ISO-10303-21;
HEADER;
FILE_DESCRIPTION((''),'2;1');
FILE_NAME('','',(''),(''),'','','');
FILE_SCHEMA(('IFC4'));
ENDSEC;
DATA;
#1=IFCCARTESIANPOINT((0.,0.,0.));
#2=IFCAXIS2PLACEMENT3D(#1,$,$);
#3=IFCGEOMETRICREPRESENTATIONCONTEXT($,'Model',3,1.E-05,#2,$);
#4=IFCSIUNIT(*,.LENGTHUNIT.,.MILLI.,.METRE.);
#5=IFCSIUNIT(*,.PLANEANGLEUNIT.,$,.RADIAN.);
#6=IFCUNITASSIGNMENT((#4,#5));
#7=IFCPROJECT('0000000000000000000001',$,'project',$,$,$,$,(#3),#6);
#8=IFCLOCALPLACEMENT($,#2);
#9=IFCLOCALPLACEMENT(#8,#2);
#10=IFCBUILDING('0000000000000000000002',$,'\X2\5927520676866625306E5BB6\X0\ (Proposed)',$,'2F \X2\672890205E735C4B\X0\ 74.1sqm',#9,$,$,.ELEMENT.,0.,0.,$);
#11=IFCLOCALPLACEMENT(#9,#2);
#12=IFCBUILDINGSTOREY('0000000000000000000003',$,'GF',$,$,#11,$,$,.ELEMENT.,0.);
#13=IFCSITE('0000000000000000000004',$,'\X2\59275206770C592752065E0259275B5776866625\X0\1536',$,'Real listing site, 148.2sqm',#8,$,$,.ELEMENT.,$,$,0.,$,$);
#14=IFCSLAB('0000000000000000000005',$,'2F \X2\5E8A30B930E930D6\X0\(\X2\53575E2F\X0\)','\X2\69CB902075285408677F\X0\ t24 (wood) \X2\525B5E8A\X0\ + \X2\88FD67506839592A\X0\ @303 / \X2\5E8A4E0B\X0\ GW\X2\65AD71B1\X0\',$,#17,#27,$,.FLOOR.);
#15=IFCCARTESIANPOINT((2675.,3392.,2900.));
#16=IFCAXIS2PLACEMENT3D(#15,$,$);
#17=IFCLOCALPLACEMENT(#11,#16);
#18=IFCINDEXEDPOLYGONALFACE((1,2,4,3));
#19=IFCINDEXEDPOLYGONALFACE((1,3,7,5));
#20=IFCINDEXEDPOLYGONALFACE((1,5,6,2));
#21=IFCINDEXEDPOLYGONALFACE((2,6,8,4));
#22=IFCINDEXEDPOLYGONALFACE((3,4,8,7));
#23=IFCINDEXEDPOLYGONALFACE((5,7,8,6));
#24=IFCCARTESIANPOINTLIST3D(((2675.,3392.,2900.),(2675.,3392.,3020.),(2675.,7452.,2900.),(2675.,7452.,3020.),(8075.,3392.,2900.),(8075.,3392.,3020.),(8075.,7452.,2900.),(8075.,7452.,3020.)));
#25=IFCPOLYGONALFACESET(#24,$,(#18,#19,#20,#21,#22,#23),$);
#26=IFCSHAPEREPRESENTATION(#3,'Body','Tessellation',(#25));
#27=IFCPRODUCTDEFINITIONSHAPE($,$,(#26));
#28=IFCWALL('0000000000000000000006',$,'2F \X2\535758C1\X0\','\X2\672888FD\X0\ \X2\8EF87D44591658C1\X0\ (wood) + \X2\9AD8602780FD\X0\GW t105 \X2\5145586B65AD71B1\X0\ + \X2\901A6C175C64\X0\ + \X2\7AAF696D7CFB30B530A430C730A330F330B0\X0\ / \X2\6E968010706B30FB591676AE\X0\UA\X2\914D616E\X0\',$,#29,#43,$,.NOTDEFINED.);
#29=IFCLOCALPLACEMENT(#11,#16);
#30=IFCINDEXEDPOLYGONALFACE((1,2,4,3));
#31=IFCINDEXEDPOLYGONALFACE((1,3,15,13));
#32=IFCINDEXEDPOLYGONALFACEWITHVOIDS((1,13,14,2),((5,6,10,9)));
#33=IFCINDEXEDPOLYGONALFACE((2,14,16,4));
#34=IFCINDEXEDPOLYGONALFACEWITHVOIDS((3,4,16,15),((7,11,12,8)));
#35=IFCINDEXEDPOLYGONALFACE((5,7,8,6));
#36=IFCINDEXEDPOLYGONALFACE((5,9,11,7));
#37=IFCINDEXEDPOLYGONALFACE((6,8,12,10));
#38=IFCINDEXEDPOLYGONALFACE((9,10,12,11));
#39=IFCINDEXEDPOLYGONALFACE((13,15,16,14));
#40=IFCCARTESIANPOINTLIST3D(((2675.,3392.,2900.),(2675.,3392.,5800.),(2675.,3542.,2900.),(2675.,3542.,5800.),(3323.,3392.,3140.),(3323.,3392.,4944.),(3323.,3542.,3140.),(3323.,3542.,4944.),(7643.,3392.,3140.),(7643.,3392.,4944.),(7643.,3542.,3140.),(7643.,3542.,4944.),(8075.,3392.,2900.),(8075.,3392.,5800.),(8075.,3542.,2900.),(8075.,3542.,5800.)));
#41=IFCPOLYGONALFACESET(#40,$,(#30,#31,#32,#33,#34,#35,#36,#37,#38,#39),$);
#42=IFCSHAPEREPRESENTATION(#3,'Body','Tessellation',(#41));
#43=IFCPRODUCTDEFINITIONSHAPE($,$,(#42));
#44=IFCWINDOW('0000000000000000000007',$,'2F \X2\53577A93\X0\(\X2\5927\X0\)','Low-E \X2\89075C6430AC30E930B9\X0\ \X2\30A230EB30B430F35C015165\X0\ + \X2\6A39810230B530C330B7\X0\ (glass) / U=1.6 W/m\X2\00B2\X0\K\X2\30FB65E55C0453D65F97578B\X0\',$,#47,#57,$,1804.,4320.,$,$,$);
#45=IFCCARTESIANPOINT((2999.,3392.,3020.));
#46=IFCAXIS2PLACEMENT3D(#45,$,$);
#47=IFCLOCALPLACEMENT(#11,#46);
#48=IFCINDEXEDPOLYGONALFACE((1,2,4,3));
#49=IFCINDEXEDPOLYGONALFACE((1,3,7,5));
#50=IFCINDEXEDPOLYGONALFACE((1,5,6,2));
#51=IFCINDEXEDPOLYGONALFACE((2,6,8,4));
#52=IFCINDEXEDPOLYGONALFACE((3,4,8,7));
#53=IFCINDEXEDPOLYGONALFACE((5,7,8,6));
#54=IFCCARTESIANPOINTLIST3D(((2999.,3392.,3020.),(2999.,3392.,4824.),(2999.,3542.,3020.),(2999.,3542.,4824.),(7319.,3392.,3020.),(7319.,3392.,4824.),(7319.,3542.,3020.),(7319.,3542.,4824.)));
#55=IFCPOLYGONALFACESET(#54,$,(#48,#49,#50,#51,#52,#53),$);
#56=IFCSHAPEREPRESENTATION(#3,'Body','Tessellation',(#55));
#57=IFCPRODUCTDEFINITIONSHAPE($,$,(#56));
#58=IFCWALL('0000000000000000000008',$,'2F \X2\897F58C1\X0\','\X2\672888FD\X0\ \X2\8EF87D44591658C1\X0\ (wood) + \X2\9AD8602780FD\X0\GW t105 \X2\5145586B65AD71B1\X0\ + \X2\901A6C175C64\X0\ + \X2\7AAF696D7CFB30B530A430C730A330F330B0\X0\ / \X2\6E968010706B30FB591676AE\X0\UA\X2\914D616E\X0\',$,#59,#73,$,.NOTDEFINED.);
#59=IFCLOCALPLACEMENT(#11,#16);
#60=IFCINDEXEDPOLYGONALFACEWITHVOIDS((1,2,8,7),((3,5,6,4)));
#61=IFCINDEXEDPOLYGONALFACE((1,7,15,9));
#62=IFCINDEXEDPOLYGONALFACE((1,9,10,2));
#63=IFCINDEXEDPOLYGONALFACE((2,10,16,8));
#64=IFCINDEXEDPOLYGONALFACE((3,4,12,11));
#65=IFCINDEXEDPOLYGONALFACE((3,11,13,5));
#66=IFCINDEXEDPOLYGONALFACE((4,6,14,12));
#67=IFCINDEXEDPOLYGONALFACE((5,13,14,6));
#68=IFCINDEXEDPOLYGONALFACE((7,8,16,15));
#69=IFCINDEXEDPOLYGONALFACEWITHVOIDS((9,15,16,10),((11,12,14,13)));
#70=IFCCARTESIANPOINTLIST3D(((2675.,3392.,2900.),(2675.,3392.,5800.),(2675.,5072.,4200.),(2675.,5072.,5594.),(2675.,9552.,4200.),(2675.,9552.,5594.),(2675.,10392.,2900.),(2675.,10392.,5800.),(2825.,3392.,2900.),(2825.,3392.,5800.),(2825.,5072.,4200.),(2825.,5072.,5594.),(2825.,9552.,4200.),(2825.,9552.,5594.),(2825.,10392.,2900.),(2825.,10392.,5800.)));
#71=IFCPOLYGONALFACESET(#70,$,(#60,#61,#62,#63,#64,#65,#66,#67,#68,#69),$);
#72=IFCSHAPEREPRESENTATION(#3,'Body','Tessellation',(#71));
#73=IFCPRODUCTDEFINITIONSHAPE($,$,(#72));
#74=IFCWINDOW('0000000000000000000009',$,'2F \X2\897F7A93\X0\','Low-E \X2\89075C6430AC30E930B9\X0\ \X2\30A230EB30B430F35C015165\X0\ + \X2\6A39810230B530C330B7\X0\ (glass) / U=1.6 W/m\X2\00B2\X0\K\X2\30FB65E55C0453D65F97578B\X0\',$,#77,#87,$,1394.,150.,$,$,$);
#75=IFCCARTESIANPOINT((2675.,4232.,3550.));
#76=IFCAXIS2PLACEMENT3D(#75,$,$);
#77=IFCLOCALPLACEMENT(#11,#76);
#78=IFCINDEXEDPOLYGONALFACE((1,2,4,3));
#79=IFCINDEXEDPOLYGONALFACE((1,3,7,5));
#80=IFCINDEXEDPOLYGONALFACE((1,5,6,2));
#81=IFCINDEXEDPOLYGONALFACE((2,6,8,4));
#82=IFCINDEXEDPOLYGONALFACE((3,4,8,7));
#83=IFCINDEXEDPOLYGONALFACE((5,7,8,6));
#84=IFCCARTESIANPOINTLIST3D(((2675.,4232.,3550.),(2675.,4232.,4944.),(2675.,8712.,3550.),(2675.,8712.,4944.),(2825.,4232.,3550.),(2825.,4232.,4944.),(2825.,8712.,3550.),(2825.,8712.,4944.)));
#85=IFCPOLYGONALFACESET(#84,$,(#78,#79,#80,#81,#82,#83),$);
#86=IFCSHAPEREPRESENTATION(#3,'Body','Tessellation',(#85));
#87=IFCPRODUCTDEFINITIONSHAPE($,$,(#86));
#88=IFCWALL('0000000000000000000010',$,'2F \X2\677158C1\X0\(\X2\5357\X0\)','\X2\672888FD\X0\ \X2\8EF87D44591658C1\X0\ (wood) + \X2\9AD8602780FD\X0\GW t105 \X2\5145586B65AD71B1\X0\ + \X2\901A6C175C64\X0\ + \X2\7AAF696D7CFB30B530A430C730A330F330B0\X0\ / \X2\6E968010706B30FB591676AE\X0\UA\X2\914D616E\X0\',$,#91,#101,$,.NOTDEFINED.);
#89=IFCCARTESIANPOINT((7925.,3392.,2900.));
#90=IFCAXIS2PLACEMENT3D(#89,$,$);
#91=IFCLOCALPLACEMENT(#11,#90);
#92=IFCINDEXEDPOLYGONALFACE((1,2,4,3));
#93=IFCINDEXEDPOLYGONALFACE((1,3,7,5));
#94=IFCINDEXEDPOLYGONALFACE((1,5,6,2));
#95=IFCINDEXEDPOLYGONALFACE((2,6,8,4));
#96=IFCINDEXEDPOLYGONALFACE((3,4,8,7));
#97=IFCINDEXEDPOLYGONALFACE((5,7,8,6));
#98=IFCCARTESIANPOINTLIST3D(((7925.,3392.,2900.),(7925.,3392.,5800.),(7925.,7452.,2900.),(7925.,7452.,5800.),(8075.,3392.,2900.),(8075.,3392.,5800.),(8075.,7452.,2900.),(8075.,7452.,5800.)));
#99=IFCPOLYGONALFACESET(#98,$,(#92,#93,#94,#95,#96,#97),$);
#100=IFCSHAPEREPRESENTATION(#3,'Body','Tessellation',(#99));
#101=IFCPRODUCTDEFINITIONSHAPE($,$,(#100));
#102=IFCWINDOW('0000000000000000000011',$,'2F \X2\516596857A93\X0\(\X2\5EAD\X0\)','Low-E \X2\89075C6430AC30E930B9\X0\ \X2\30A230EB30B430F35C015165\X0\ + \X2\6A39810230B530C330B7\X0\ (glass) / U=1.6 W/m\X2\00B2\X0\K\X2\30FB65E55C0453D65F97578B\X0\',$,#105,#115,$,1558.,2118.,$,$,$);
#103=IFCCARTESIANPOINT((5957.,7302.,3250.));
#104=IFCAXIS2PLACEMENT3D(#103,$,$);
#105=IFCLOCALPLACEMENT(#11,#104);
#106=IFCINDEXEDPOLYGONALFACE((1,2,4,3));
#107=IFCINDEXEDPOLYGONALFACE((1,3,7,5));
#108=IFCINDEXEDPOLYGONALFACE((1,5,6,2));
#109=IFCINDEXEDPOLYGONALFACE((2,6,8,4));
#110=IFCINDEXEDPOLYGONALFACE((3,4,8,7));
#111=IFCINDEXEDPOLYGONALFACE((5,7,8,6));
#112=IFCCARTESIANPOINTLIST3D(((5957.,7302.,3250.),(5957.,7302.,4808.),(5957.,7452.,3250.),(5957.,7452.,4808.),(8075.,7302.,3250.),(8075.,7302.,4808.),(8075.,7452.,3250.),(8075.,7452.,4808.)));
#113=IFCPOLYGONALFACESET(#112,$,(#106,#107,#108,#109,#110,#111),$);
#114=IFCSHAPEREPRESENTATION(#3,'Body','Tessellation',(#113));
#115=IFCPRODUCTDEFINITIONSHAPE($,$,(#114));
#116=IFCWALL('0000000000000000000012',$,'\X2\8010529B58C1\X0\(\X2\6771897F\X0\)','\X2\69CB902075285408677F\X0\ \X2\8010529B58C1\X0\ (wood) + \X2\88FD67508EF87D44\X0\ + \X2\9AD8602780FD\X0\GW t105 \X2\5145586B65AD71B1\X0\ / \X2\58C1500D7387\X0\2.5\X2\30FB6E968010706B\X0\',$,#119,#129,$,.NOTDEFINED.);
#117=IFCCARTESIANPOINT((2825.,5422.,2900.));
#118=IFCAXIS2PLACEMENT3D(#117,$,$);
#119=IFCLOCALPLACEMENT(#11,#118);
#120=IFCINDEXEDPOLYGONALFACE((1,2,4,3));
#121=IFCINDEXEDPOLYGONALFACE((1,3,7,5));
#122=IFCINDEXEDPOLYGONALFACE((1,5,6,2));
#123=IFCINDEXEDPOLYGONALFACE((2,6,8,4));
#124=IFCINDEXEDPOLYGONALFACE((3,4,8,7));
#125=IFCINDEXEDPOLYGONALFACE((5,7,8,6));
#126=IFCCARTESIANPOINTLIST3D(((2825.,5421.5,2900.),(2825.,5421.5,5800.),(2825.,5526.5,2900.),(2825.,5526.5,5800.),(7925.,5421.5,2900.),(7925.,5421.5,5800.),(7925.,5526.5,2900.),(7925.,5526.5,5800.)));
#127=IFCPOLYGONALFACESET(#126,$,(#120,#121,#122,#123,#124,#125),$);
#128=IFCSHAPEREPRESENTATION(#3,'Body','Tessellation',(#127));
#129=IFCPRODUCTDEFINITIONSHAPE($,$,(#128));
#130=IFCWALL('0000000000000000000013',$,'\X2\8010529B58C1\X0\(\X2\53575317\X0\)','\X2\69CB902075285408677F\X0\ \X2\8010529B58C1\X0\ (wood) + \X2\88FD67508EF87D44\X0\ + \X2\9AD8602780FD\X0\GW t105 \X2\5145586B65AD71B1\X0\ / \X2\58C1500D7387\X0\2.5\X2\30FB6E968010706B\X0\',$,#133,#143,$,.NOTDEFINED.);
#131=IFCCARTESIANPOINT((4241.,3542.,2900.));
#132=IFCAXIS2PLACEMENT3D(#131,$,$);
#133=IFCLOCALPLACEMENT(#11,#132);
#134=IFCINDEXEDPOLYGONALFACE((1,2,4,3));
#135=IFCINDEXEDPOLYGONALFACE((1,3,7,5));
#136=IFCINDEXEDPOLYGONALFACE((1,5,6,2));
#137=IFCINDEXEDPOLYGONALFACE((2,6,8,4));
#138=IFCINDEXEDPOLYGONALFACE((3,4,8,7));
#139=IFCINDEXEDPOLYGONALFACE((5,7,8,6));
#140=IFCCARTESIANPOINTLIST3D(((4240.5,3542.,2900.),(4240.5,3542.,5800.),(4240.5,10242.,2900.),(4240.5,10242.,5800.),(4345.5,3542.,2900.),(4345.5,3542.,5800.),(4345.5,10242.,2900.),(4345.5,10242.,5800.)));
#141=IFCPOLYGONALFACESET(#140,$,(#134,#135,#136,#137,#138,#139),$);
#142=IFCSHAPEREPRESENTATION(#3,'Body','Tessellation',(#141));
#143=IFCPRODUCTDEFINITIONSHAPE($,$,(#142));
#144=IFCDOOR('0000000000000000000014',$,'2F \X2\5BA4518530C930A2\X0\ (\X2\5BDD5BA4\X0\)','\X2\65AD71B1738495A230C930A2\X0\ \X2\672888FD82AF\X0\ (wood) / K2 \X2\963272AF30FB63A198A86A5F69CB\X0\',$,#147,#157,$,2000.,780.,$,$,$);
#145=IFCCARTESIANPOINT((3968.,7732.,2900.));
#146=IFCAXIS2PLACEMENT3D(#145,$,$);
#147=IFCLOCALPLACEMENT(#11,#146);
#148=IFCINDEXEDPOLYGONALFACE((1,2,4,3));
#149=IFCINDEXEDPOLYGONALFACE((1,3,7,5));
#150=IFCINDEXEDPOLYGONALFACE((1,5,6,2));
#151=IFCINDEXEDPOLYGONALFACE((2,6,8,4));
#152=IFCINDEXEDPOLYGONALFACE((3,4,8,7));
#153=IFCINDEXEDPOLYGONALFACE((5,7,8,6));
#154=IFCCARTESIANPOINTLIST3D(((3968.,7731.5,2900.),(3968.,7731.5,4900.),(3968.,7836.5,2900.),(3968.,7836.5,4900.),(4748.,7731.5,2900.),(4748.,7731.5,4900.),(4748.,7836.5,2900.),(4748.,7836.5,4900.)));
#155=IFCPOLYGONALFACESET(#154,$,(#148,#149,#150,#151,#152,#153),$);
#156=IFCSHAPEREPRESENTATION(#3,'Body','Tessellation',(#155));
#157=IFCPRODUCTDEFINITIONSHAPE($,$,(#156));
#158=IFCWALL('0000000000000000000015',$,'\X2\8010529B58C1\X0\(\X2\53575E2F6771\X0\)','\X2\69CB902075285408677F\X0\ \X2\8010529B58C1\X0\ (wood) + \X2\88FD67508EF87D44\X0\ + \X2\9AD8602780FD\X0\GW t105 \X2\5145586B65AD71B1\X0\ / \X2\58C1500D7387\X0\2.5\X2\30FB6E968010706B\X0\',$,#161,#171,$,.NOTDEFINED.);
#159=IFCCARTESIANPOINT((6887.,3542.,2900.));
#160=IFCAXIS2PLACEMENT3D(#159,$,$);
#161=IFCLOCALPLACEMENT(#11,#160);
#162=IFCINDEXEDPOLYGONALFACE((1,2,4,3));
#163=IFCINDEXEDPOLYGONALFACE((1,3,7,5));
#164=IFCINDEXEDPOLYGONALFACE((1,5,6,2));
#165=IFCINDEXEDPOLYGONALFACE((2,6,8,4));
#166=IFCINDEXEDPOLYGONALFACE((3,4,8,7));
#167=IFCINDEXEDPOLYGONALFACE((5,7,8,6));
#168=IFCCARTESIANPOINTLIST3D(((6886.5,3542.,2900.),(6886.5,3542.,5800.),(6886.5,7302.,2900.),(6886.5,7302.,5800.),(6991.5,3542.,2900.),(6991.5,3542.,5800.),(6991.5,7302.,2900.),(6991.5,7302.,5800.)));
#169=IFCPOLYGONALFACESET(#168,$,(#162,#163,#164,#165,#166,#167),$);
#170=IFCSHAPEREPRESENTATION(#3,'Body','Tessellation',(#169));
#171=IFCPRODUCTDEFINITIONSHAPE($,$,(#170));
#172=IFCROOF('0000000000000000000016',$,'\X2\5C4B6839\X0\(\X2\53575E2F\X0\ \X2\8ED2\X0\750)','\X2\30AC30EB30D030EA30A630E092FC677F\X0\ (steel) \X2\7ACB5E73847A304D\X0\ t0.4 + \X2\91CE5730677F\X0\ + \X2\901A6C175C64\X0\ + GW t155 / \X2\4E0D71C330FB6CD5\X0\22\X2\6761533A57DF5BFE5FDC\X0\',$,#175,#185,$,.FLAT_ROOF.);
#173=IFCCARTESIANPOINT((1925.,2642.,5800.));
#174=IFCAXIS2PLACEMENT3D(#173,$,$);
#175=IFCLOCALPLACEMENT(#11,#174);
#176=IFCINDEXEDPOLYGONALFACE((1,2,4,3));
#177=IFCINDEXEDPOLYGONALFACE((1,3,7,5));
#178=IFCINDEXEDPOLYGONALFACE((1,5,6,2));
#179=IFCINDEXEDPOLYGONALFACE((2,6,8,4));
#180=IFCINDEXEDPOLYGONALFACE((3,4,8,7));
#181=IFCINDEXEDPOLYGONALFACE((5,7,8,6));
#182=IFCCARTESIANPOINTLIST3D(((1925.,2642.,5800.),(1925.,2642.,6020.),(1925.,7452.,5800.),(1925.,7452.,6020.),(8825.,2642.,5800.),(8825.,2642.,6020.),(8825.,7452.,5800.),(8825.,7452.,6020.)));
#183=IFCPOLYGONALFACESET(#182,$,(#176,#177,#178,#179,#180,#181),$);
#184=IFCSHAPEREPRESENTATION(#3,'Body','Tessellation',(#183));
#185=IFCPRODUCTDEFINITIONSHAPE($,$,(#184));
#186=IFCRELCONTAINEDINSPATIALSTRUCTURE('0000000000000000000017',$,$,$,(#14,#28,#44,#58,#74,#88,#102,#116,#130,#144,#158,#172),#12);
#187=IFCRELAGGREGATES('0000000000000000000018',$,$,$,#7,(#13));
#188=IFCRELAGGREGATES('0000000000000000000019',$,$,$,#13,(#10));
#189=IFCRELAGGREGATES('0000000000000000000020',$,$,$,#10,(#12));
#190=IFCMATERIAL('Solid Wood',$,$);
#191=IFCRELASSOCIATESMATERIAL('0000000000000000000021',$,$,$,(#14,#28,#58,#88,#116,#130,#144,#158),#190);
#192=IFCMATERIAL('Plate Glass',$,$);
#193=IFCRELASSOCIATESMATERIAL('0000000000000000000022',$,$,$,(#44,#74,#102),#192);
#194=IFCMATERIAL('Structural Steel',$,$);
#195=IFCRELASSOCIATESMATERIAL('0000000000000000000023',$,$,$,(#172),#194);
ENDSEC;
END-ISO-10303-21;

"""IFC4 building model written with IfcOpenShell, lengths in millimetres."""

from ifc_helpers import new_model, si_unit, frame, frame_2d, origin, place, context, project, spatial, rectangle, extrude, material, element, fill, save


model = new_model("IFC4")

# Units and contexts
model_context = context("Model", 3, precision=1e-05, world=origin())
ifc_project = project(units=[si_unit("LENGTHUNIT", "METRE", prefix="MILLI"), si_unit("PLANEANGLEUNIT", "RADIAN")], contexts=[model_context])

# Site, building, storey
site_placement = place(None, origin())
site = spatial("IfcSite", under=ifc_project, at=site_placement, Name="大分県大分市大字皆春1536", ObjectType="Real listing site, 148.2sqm", CompositionType="ELEMENT", RefElevation=0.0)
building_placement = place(site_placement, origin())
building = spatial("IfcBuilding", under=site, at=building_placement, Name="大分皆春の家 (Proposed)", ObjectType="2F 木造平屋 74.1sqm", CompositionType="ELEMENT", ElevationOfRefHeight=0.0, ElevationOfTerrain=0.0)
storey_placement = place(building_placement, origin())
storey = spatial("IfcBuildingStorey", under=building, at=storey_placement, Name="GF", CompositionType="ELEMENT", Elevation=0.0)

# Slab
ifc_material_1 = material(Name="Solid Wood")
slab_placement = place(storey_placement, frame((2675.0, 3392.0, 2900.0)))
element("IfcSlab", 1, at=slab_placement, inside=storey, material=ifc_material_1, Name="2F 床スラブ(南帯)", Description="構造用合板 t24 (wood) 剛床 + 製材根太 @303 / 床下 GW断熱", PredefinedType="FLOOR", context=model_context, shape_type="SweptSolid", body=[
    extrude(rectangle(XDim=5400.0, YDim=4060.0, at=frame_2d((2700.0, 2030.0))), frame((2675.0, 3392.0, 2900.0)), (0.0, 0.0, 1.0), 120.0),
])

# Walls, openings, windows
wall_1_placement = place(storey_placement, frame((2675.0, 3392.0, 2900.0)))
wall_1 = element("IfcWall", 2, at=wall_1_placement, inside=storey, material=ifc_material_1, Name="2F 南壁", Description="木製 軸組外壁 (wood) + 高性能GW t105 充填断熱 + 通気層 + 窯業系サイディング / 準耐火・外皮UA配慮", PredefinedType="NOTDEFINED", context=model_context, shape_type="SweptSolid", body=[
    extrude(rectangle(XDim=5400.0, YDim=150.0, at=frame_2d((2700.0, 75.0))), frame((2675.0, 3392.0, 2900.0)), (0.0, 0.0, 1.0), 2900.0),
])
opening_1_placement = place(storey_placement, frame((2999.0, 3392.0, 3020.0)))
opening_1 = element("IfcOpeningElement", 3, at=opening_1_placement, cuts=wall_1, PredefinedType="NOTDEFINED", context=model_context, shape_type="SweptSolid", body=[
    extrude(rectangle(XDim=4320.0, YDim=150.0, at=frame_2d((2160.0, 75.0))), frame((2999.0, 3392.0, 3020.0)), (0.0, 0.0, 1.0), 1804.0),
])
ifc_material_2 = material(Name="Plate Glass")
window_1_placement = place(storey_placement, frame((2999.0, 3392.0, 3020.0)))
window_1 = element("IfcWindow", 4, at=window_1_placement, inside=storey, material=ifc_material_2, Name="2F 南窓(大)", Description="Low-E 複層ガラス アルゴン封入 + 樹脂サッシ (glass) / U=1.6 W/m²K・日射取得型", OverallHeight=1804.0, OverallWidth=4320.0, context=model_context, shape_type="SweptSolid", body=[
    extrude(rectangle(XDim=4320.0, YDim=150.0, at=frame_2d((2160.0, 75.0))), frame((2999.0, 3392.0, 3020.0)), (0.0, 0.0, 1.0), 1804.0),
])
fill(opening_1, window_1)
wall_2_placement = place(storey_placement, frame((2675.0, 3392.0, 2900.0)))
wall_2 = element("IfcWall", 5, at=wall_2_placement, inside=storey, material=ifc_material_1, Name="2F 西壁", Description="木製 軸組外壁 (wood) + 高性能GW t105 充填断熱 + 通気層 + 窯業系サイディング / 準耐火・外皮UA配慮", PredefinedType="NOTDEFINED", context=model_context, shape_type="SweptSolid", body=[
    extrude(rectangle(XDim=150.0, YDim=7000.0, at=frame_2d((75.0, 3500.0))), frame((2675.0, 3392.0, 2900.0)), (0.0, 0.0, 1.0), 2900.0),
])
opening_2_placement = place(storey_placement, frame((2675.0, 4232.0, 3550.0)))
opening_2 = element("IfcOpeningElement", 6, at=opening_2_placement, cuts=wall_2, PredefinedType="NOTDEFINED", context=model_context, shape_type="SweptSolid", body=[
    extrude(rectangle(XDim=150.0, YDim=4480.0, at=frame_2d((75.0, 2240.0))), frame((2675.0, 4232.0, 3550.0)), (0.0, 0.0, 1.0), 1394.0),
])
window_2_placement = place(storey_placement, frame((2675.0, 4232.0, 3550.0)))
window_2 = element("IfcWindow", 7, at=window_2_placement, inside=storey, material=ifc_material_2, Name="2F 西窓", Description="Low-E 複層ガラス アルゴン封入 + 樹脂サッシ (glass) / U=1.6 W/m²K・日射取得型", OverallHeight=1394.0, OverallWidth=150.0, context=model_context, shape_type="SweptSolid", body=[
    extrude(rectangle(XDim=150.0, YDim=4480.0, at=frame_2d((75.0, 2240.0))), frame((2675.0, 4232.0, 3550.0)), (0.0, 0.0, 1.0), 1394.0),
])
fill(opening_2, window_2)
wall_3_placement = place(storey_placement, frame((7925.0, 3392.0, 2900.0)))
wall_3 = element("IfcWall", 8, at=wall_3_placement, inside=storey, material=ifc_material_1, Name="2F 東壁(南)", Description="木製 軸組外壁 (wood) + 高性能GW t105 充填断熱 + 通気層 + 窯業系サイディング / 準耐火・外皮UA配慮", PredefinedType="NOTDEFINED", context=model_context, shape_type="SweptSolid", body=[
    extrude(rectangle(XDim=150.0, YDim=4060.0, at=frame_2d((75.0, 2030.0))), frame((7925.0, 3392.0, 2900.0)), (0.0, 0.0, 1.0), 2900.0),
])
opening_3_placement = place(storey_placement, frame((5957.0, 7302.0, 3250.0)))
opening_3 = element("IfcOpeningElement", 9, at=opening_3_placement, cuts=wall_3, PredefinedType="NOTDEFINED", context=model_context, shape_type="SweptSolid", body=[
    extrude(rectangle(XDim=2118.0, YDim=150.0, at=frame_2d((1059.0, 75.0))), frame((5957.0, 7302.0, 3250.0)), (0.0, 0.0, 1.0), 1558.0),
])
window_3_placement = place(storey_placement, frame((5957.0, 7302.0, 3250.0)))
window_3 = element("IfcWindow", 10, at=window_3_placement, inside=storey, material=ifc_material_2, Name="2F 入隅窓(庭)", Description="Low-E 複層ガラス アルゴン封入 + 樹脂サッシ (glass) / U=1.6 W/m²K・日射取得型", OverallHeight=1558.0, OverallWidth=2118.0, context=model_context, shape_type="SweptSolid", body=[
    extrude(rectangle(XDim=2118.0, YDim=150.0, at=frame_2d((1059.0, 75.0))), frame((5957.0, 7302.0, 3250.0)), (0.0, 0.0, 1.0), 1558.0),
])
fill(opening_3, window_3)

# Wall
wall_4_placement = place(storey_placement, frame((2825.0, 5422.0, 2900.0)))
element("IfcWall", 11, at=wall_4_placement, inside=storey, material=ifc_material_1, Name="耐力壁(東西)", Description="構造用合板 耐力壁 (wood) + 製材軸組 + 高性能GW t105 充填断熱 / 壁倍率2.5・準耐火", PredefinedType="NOTDEFINED", context=model_context, shape_type="SweptSolid", body=[
    extrude(rectangle(XDim=5100.0, YDim=105.0, at=frame_2d((2550.0, 52.0))), frame((2825.0, 5422.0, 2900.0)), (0.0, 0.0, 1.0), 2900.0),
])

# Wall, opening, door
wall_5_placement = place(storey_placement, frame((4241.0, 3542.0, 2900.0)))
wall_5 = element("IfcWall", 12, at=wall_5_placement, inside=storey, material=ifc_material_1, Name="耐力壁(南北)", Description="構造用合板 耐力壁 (wood) + 製材軸組 + 高性能GW t105 充填断熱 / 壁倍率2.5・準耐火", PredefinedType="NOTDEFINED", context=model_context, shape_type="SweptSolid", body=[
    extrude(rectangle(XDim=105.0, YDim=6700.0, at=frame_2d((52.0, 3350.0))), frame((4241.0, 3542.0, 2900.0)), (0.0, 0.0, 1.0), 2900.0),
])
opening_4_placement = place(storey_placement, frame((3968.0, 7732.0, 2900.0)))
opening_4 = element("IfcOpeningElement", 13, at=opening_4_placement, cuts=wall_5, PredefinedType="NOTDEFINED", context=model_context, shape_type="SweptSolid", body=[
    extrude(rectangle(XDim=780.0, YDim=105.0, at=frame_2d((390.0, 52.0))), frame((3968.0, 7732.0, 2900.0)), (0.0, 0.0, 1.0), 2000.0),
])
door_placement = place(storey_placement, frame((3968.0, 7732.0, 2900.0)))
door = element("IfcDoor", 14, at=door_placement, inside=storey, material=ifc_material_1, Name="2F 室内ドア (寝室)", Description="断熱玄関ドア 木製芯 (wood) / K2 防犯・採風機構", OverallHeight=2000.0, OverallWidth=780.0, context=model_context, shape_type="SweptSolid", body=[
    extrude(rectangle(XDim=780.0, YDim=105.0, at=frame_2d((390.0, 52.0))), frame((3968.0, 7732.0, 2900.0)), (0.0, 0.0, 1.0), 2000.0),
])
fill(opening_4, door)

# Wall
wall_6_placement = place(storey_placement, frame((6887.0, 3542.0, 2900.0)))
element("IfcWall", 15, at=wall_6_placement, inside=storey, material=ifc_material_1, Name="耐力壁(南帯東)", Description="構造用合板 耐力壁 (wood) + 製材軸組 + 高性能GW t105 充填断熱 / 壁倍率2.5・準耐火", PredefinedType="NOTDEFINED", context=model_context, shape_type="SweptSolid", body=[
    extrude(rectangle(XDim=105.0, YDim=3760.0, at=frame_2d((52.0, 1880.0))), frame((6887.0, 3542.0, 2900.0)), (0.0, 0.0, 1.0), 2900.0),
])

# Roof
ifc_material_3 = material(Name="Structural Steel")
for number, where, name in (
    (16, (1925.0, 2642.0, 5800.0), "屋根(南帯 軒750)"),
):
    element("IfcRoof", number, at=place(storey_placement, frame(where)), inside=storey, material=ifc_material_3, Name=name, Description="ガルバリウム鋼板 (steel) 立平葺き t0.4 + 野地板 + 通気層 + GW t155 / 不燃・法22条区域対応", PredefinedType="FLAT_ROOF", context=model_context, shape_type="SweptSolid", body=[
        extrude(rectangle(XDim=6900.0, YDim=4810.0, at=frame_2d((3450.0, 2405.0))), frame((1925.0, 2642.0, 5800.0)), (0.0, 0.0, 1.0), 220.0),
    ])

save(model, "model.ifc")
